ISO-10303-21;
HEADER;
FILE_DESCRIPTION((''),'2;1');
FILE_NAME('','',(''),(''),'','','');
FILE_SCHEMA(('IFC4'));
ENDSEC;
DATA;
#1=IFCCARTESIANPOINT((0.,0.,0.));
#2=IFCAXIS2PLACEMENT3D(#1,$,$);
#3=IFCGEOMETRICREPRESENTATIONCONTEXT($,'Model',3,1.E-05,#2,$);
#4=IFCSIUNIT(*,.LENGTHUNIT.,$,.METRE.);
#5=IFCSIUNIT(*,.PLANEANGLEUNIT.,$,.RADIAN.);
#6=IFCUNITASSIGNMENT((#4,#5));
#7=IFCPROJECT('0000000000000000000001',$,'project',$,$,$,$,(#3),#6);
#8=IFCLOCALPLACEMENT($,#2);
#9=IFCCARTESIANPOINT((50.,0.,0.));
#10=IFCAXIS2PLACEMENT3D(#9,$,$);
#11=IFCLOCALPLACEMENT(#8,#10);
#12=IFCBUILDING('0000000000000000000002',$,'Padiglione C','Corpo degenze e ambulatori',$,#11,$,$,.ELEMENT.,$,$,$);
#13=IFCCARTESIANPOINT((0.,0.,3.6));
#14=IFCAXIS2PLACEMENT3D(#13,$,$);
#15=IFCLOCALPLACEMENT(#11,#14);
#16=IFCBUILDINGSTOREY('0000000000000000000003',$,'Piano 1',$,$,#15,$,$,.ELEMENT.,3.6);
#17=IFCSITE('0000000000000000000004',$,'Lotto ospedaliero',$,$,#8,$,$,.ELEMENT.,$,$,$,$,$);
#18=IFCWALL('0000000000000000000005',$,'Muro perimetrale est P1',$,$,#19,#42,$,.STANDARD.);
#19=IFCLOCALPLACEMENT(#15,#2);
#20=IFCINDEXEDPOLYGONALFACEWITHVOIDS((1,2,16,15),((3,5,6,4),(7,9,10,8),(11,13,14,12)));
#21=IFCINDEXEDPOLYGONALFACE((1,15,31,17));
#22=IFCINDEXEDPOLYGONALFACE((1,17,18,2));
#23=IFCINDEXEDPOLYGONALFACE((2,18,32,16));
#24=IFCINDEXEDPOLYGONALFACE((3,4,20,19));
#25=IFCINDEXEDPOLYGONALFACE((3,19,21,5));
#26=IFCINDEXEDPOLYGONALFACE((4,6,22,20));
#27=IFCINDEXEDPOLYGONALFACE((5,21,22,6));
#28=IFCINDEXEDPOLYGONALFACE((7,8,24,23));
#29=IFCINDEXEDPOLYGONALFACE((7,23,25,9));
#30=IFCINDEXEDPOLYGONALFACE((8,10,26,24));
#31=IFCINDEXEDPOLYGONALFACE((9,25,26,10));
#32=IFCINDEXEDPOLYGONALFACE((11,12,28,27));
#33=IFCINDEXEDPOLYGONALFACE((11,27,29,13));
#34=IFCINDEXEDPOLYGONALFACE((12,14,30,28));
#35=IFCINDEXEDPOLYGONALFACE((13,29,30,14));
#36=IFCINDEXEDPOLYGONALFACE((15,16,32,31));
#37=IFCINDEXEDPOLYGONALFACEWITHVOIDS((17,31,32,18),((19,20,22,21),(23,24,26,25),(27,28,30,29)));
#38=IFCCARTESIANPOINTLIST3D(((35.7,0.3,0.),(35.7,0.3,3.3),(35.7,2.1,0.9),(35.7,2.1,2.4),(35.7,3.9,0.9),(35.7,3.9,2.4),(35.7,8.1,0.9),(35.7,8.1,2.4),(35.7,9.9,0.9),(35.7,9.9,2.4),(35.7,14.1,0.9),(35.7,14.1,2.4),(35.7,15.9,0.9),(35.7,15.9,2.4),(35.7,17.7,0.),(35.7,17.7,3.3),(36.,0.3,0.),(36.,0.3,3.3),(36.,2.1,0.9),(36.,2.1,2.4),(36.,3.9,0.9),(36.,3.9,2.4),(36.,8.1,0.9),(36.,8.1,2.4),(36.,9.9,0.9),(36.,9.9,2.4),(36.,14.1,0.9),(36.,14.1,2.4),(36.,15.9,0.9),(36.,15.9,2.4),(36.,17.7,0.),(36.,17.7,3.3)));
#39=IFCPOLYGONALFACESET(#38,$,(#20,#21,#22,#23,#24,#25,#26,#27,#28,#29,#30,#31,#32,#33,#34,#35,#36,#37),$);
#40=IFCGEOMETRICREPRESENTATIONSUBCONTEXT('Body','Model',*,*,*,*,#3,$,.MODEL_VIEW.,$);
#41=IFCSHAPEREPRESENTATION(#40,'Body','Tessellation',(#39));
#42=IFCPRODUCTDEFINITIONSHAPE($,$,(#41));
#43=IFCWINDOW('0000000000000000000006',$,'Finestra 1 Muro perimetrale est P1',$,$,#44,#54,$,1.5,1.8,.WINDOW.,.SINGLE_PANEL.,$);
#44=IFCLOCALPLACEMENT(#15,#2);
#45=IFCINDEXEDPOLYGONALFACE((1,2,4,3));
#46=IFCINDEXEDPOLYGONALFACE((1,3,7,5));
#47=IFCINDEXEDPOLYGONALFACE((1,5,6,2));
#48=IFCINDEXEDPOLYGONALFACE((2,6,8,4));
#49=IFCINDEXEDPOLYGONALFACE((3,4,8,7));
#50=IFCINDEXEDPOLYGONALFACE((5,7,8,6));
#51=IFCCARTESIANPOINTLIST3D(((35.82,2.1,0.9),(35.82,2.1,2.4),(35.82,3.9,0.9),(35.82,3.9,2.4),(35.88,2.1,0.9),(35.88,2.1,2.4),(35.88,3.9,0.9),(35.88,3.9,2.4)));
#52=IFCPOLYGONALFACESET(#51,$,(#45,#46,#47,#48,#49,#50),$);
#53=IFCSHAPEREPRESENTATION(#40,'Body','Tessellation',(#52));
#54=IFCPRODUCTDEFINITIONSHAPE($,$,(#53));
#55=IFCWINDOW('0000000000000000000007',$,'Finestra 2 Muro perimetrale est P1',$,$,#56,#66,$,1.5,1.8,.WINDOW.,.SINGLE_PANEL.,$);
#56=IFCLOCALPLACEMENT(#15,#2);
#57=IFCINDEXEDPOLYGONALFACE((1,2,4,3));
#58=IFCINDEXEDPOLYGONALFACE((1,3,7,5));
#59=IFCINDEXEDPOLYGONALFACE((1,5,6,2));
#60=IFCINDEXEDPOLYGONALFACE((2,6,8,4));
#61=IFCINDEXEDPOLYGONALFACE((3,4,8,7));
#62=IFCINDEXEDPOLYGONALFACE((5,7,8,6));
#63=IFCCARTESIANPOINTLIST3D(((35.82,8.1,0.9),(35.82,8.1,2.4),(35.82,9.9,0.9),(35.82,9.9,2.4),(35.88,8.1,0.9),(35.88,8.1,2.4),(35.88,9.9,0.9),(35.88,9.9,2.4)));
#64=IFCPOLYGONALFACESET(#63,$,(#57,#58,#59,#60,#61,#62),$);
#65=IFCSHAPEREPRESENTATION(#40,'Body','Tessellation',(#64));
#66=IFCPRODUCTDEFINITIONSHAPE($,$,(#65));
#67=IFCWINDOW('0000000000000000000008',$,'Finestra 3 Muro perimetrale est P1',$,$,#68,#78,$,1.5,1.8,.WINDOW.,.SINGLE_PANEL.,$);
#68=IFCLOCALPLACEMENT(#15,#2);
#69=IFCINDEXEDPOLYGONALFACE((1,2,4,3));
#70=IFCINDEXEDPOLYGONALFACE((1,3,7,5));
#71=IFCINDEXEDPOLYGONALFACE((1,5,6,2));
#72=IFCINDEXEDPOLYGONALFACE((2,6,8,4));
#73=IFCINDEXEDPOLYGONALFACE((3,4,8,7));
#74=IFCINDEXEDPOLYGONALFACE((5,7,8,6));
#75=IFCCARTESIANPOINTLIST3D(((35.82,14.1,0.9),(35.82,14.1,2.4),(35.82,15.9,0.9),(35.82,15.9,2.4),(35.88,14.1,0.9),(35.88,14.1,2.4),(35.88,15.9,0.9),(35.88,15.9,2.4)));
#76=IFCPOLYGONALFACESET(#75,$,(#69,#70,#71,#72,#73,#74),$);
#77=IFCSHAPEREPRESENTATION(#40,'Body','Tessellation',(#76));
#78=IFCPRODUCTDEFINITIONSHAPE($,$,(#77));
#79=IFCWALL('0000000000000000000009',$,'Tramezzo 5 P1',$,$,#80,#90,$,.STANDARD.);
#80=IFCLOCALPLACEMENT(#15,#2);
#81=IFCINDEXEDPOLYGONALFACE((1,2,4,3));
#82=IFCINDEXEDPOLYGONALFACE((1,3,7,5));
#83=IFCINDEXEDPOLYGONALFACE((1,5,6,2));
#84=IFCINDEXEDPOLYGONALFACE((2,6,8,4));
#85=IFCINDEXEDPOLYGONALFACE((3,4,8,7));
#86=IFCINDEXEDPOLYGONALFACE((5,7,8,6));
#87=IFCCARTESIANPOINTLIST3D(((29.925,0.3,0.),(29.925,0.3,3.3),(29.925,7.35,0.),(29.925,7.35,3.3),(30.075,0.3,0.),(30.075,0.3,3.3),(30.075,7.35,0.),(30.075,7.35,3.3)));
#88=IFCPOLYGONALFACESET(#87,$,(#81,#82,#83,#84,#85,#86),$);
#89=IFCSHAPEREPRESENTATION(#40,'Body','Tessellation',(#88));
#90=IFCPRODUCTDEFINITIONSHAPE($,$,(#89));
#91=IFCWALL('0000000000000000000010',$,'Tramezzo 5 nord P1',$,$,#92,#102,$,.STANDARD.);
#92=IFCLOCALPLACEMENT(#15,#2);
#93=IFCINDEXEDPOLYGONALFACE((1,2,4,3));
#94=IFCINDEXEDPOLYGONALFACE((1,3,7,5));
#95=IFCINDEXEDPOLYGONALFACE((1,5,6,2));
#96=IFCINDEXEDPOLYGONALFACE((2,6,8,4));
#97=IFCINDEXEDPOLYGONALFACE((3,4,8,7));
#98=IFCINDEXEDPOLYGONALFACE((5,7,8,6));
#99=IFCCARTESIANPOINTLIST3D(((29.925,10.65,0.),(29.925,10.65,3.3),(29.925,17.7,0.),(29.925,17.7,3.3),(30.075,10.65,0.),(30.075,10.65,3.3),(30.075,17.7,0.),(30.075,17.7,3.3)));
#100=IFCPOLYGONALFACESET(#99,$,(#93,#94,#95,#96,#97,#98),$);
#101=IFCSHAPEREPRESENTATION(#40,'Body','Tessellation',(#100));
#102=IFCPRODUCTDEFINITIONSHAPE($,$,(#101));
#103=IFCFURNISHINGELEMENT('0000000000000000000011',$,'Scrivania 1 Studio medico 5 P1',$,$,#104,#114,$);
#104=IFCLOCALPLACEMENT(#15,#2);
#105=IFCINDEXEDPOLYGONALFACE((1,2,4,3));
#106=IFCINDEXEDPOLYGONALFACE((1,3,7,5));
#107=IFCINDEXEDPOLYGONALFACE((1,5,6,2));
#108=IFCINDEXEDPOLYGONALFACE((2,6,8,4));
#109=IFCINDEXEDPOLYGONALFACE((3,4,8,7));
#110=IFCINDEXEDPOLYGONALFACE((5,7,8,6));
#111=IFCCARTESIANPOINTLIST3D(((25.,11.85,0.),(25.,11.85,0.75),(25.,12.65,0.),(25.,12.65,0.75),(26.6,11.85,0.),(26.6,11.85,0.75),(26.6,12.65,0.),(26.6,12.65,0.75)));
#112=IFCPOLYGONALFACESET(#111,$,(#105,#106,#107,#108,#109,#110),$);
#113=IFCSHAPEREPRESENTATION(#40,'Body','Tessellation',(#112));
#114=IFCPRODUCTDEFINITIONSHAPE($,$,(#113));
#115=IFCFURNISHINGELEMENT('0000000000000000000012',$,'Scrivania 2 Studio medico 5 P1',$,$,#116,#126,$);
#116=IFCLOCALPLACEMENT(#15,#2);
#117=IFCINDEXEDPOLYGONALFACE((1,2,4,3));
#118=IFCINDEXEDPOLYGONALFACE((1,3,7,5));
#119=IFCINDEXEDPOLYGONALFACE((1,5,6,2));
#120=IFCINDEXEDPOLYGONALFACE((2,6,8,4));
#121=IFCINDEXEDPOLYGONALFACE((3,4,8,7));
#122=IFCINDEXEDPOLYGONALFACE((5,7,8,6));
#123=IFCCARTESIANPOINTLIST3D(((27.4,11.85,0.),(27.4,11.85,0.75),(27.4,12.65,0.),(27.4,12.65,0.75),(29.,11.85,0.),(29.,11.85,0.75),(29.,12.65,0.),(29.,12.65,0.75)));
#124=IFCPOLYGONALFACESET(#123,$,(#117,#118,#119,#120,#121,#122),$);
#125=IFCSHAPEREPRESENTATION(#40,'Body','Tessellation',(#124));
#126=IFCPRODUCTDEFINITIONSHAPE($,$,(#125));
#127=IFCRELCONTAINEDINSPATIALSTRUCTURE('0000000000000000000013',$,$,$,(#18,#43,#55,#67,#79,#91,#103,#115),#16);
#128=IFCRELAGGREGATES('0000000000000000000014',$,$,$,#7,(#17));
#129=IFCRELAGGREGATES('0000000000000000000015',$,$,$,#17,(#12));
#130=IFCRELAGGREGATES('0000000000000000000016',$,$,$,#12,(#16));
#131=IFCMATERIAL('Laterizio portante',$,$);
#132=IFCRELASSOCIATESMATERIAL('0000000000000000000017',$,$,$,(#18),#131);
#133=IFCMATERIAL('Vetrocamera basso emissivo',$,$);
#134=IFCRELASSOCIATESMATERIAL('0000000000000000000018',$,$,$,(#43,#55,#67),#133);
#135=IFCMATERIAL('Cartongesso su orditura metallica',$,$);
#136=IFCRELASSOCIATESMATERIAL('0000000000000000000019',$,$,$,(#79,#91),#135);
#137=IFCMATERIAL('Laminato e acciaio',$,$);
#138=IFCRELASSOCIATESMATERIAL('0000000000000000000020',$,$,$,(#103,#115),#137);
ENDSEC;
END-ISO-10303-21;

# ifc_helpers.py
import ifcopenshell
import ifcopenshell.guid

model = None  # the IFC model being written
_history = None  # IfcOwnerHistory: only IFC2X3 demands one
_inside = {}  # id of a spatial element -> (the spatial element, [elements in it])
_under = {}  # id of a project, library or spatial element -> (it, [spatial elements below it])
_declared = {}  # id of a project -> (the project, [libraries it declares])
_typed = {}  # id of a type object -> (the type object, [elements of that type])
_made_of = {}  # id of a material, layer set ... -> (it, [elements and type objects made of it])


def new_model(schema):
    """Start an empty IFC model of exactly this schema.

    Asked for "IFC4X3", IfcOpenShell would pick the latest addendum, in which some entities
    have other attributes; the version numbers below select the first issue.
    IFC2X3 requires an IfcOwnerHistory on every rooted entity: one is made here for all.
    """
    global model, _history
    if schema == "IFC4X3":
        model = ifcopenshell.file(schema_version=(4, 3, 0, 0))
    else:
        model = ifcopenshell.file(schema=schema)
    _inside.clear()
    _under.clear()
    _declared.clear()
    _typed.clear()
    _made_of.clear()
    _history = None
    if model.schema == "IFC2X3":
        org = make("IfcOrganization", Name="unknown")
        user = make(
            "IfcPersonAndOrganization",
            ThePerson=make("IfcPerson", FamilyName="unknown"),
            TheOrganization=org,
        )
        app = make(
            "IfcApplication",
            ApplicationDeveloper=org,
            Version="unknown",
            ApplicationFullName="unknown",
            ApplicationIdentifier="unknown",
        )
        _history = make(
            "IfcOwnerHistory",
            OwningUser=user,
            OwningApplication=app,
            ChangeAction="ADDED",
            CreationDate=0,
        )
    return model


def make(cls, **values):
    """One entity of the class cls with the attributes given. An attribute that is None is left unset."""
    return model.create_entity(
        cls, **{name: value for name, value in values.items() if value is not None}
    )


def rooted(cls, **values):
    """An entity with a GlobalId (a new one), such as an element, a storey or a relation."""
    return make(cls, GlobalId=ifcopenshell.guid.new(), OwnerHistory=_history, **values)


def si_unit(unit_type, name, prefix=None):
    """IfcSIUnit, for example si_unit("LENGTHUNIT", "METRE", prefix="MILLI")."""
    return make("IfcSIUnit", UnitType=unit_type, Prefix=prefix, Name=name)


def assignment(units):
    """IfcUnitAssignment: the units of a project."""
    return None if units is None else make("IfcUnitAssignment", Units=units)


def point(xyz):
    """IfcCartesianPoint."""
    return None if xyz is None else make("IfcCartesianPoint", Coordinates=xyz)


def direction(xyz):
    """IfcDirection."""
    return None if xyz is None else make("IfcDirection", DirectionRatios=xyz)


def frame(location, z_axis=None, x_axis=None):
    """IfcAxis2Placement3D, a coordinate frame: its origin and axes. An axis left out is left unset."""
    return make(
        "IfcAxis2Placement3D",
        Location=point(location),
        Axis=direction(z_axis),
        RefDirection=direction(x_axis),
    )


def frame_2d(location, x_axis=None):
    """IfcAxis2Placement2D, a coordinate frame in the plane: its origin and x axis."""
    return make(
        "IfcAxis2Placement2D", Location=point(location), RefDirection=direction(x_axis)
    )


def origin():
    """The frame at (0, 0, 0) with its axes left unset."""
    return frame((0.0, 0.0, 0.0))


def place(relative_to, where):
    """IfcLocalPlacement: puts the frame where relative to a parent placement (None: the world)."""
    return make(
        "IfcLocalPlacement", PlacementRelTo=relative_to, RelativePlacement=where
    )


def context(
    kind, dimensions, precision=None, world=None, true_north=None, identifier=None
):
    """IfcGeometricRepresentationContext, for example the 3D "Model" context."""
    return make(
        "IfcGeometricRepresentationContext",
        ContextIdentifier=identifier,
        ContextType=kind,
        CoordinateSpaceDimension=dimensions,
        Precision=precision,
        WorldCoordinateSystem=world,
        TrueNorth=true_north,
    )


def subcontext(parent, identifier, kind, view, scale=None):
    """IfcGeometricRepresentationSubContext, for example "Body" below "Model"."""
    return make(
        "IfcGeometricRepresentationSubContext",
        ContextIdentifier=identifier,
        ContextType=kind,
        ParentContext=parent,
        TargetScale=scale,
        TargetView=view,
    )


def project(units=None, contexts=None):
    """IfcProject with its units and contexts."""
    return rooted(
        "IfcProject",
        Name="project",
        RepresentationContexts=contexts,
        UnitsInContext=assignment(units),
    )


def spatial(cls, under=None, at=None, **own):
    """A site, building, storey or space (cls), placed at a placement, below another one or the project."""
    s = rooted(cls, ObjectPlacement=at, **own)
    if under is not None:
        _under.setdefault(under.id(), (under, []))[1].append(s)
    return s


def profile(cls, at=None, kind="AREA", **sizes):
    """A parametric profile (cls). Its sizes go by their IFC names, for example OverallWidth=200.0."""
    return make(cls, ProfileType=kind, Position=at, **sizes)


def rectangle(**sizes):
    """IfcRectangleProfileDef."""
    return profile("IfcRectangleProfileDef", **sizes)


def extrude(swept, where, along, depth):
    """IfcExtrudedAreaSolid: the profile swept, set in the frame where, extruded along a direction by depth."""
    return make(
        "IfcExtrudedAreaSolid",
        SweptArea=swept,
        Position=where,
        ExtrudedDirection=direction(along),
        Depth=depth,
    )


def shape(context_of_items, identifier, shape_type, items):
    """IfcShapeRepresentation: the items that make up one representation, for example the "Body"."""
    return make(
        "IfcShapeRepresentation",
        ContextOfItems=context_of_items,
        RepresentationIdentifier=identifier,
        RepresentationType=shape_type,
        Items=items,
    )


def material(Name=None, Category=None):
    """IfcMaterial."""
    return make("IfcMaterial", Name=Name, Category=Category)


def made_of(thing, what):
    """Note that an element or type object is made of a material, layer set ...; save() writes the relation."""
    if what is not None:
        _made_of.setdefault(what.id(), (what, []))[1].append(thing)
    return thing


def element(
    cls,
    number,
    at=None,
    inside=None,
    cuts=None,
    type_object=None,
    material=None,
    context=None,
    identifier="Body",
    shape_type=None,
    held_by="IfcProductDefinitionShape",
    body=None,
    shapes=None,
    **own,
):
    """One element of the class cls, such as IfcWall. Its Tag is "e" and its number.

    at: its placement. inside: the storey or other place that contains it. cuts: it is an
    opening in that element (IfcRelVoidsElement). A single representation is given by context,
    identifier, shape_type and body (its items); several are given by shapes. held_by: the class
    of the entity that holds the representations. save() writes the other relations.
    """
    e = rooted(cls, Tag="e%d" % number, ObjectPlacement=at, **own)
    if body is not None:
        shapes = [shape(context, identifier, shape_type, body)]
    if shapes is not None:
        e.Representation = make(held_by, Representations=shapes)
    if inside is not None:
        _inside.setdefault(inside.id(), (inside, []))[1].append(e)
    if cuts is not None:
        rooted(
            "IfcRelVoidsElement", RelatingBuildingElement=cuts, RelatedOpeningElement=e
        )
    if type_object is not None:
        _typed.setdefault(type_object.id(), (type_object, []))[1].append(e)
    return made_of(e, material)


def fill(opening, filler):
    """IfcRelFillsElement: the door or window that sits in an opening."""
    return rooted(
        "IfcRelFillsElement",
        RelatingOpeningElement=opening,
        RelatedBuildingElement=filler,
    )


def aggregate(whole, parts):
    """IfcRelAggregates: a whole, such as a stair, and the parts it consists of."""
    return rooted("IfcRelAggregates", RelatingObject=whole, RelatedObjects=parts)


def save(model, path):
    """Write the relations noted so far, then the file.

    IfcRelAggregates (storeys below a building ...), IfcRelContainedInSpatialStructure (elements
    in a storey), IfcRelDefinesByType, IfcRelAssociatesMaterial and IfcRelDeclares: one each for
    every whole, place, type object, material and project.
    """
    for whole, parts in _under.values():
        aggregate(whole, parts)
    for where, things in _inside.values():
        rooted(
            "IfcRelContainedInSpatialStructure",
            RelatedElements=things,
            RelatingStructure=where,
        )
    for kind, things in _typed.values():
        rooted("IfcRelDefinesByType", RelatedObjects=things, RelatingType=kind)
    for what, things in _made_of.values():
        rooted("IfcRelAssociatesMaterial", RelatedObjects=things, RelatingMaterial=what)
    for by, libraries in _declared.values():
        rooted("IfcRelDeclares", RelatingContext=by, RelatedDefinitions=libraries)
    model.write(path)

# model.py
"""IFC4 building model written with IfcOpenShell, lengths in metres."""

from ifc_helpers import new_model, si_unit, frame, frame_2d, origin, place, context, subcontext, project, spatial, rectangle, extrude, material, element, fill, save


model = new_model("IFC4")

# Units and contexts
model_context = context("Model", 3, precision=1e-05, world=origin())
body_context = subcontext(model_context, "Body", "Model", "MODEL_VIEW")
ifc_project = project(units=[si_unit("LENGTHUNIT", "METRE"), si_unit("PLANEANGLEUNIT", "RADIAN")], contexts=[model_context])

# Site, building, storey
site_placement = place(None, origin())
site = spatial("IfcSite", under=ifc_project, at=site_placement, Name="Lotto ospedaliero", CompositionType="ELEMENT")
building_placement = place(site_placement, frame((50.0, 0.0, 0.0)))
building = spatial("IfcBuilding", under=site, at=building_placement, Name="Padiglione C", Description="Corpo degenze e ambulatori", CompositionType="ELEMENT")
storey_placement = place(building_placement, frame((0.0, 0.0, 3.6)))
storey = spatial("IfcBuildingStorey", under=building, at=storey_placement, Name="Piano 1", CompositionType="ELEMENT", Elevation=3.6)

# Wall, openings, windows
ifc_material_1 = material(Name="Laterizio portante")
wall_placement = place(storey_placement, frame((35.7, 0.3, 0.0)))
wall = element("IfcWall", 1, at=wall_placement, inside=storey, material=ifc_material_1, Name="Muro perimetrale est P1", PredefinedType="STANDARD", context=body_context, shape_type="SweptSolid", body=[
    extrude(rectangle(XDim=0.3, YDim=17.4, at=frame_2d((0.15, 8.7))), origin(), (0.0, 0.0, 1.0), 3.3),
])
opening_1_placement = place(wall_placement, frame((-0.1, 1.8, 0.9)))
opening_1 = element("IfcOpeningElement", 2, at=opening_1_placement, cuts=wall, PredefinedType="OPENING", context=body_context, shape_type="SweptSolid", body=[
    extrude(rectangle(XDim=0.5, YDim=1.8, at=frame_2d((0.25, 0.9))), origin(), (0.0, 0.0, 1.0), 1.5),
])
opening_2_placement = place(wall_placement, frame((-0.1, 7.8, 0.9)))
opening_2 = element("IfcOpeningElement", 3, at=opening_2_placement, cuts=wall, PredefinedType="OPENING", context=body_context, shape_type="SweptSolid", body=[
    extrude(rectangle(XDim=0.5, YDim=1.8, at=frame_2d((0.25, 0.9))), origin(), (0.0, 0.0, 1.0), 1.5),
])
opening_3_placement = place(wall_placement, frame((-0.1, 13.8, 0.9)))
opening_3 = element("IfcOpeningElement", 4, at=opening_3_placement, cuts=wall, PredefinedType="OPENING", context=body_context, shape_type="SweptSolid", body=[
    extrude(rectangle(XDim=0.5, YDim=1.8, at=frame_2d((0.25, 0.9))), origin(), (0.0, 0.0, 1.0), 1.5),
])
ifc_material_2 = material(Name="Vetrocamera basso emissivo")
window_1_placement = place(wall_placement, frame((0.12, 1.8, 0.9)))
window_1 = element("IfcWindow", 5, at=window_1_placement, inside=storey, material=ifc_material_2, Name="Finestra 1 Muro perimetrale est P1", OverallHeight=1.5, OverallWidth=1.8, PartitioningType="SINGLE_PANEL", PredefinedType="WINDOW", context=body_context, shape_type="SweptSolid", body=[
    extrude(rectangle(XDim=0.06, YDim=1.8, at=frame_2d((0.03, 0.9))), origin(), (0.0, 0.0, 1.0), 1.5),
])
fill(opening_1, window_1)
window_2_placement = place(wall_placement, frame((0.12, 7.8, 0.9)))
window_2 = element("IfcWindow", 6, at=window_2_placement, inside=storey, material=ifc_material_2, Name="Finestra 2 Muro perimetrale est P1", OverallHeight=1.5, OverallWidth=1.8, PartitioningType="SINGLE_PANEL", PredefinedType="WINDOW", context=body_context, shape_type="SweptSolid", body=[
    extrude(rectangle(XDim=0.06, YDim=1.8, at=frame_2d((0.03, 0.9))), origin(), (0.0, 0.0, 1.0), 1.5),
])
fill(opening_2, window_2)
window_3_placement = place(wall_placement, frame((0.12, 13.8, 0.9)))
window_3 = element("IfcWindow", 7, at=window_3_placement, inside=storey, material=ifc_material_2, Name="Finestra 3 Muro perimetrale est P1", OverallHeight=1.5, OverallWidth=1.8, PartitioningType="SINGLE_PANEL", PredefinedType="WINDOW", context=body_context, shape_type="SweptSolid", body=[
    extrude(rectangle(XDim=0.06, YDim=1.8, at=frame_2d((0.03, 0.9))), origin(), (0.0, 0.0, 1.0), 1.5),
])
fill(opening_3, window_3)

# Walls
ifc_material_3 = material(Name="Cartongesso su orditura metallica")
for number, where, name in (
    (8, (29.925, 0.3, 0.0), "Tramezzo 5 P1"),
    (9, (29.925, 10.65, 0.0), "Tramezzo 5 nord P1"),
):
    element("IfcWall", number, at=place(storey_placement, frame(where)), inside=storey, material=ifc_material_3, Name=name, PredefinedType="STANDARD", context=body_context, shape_type="SweptSolid", body=[
        extrude(rectangle(XDim=0.15, YDim=7.05, at=frame_2d((0.075, 3.525))), origin(), (0.0, 0.0, 1.0), 3.3),
    ])

# Furnishing elements
ifc_material_4 = material(Name="Laminato e acciaio")
for number, where, name in (
    (10, (25.0, 11.85, 0.0), "Scrivania 1 Studio medico 5 P1"),
    (11, (27.4, 11.85, 0.0), "Scrivania 2 Studio medico 5 P1"),
):
    element("IfcFurnishingElement", number, at=place(storey_placement, frame(where)), inside=storey, material=ifc_material_4, Name=name, context=body_context, shape_type="SweptSolid", body=[
        extrude(rectangle(XDim=1.6, YDim=0.8, at=frame_2d((0.8, 0.4))), origin(), (0.0, 0.0, 1.0), 0.75),
    ])

save(model, "model.ifc")
